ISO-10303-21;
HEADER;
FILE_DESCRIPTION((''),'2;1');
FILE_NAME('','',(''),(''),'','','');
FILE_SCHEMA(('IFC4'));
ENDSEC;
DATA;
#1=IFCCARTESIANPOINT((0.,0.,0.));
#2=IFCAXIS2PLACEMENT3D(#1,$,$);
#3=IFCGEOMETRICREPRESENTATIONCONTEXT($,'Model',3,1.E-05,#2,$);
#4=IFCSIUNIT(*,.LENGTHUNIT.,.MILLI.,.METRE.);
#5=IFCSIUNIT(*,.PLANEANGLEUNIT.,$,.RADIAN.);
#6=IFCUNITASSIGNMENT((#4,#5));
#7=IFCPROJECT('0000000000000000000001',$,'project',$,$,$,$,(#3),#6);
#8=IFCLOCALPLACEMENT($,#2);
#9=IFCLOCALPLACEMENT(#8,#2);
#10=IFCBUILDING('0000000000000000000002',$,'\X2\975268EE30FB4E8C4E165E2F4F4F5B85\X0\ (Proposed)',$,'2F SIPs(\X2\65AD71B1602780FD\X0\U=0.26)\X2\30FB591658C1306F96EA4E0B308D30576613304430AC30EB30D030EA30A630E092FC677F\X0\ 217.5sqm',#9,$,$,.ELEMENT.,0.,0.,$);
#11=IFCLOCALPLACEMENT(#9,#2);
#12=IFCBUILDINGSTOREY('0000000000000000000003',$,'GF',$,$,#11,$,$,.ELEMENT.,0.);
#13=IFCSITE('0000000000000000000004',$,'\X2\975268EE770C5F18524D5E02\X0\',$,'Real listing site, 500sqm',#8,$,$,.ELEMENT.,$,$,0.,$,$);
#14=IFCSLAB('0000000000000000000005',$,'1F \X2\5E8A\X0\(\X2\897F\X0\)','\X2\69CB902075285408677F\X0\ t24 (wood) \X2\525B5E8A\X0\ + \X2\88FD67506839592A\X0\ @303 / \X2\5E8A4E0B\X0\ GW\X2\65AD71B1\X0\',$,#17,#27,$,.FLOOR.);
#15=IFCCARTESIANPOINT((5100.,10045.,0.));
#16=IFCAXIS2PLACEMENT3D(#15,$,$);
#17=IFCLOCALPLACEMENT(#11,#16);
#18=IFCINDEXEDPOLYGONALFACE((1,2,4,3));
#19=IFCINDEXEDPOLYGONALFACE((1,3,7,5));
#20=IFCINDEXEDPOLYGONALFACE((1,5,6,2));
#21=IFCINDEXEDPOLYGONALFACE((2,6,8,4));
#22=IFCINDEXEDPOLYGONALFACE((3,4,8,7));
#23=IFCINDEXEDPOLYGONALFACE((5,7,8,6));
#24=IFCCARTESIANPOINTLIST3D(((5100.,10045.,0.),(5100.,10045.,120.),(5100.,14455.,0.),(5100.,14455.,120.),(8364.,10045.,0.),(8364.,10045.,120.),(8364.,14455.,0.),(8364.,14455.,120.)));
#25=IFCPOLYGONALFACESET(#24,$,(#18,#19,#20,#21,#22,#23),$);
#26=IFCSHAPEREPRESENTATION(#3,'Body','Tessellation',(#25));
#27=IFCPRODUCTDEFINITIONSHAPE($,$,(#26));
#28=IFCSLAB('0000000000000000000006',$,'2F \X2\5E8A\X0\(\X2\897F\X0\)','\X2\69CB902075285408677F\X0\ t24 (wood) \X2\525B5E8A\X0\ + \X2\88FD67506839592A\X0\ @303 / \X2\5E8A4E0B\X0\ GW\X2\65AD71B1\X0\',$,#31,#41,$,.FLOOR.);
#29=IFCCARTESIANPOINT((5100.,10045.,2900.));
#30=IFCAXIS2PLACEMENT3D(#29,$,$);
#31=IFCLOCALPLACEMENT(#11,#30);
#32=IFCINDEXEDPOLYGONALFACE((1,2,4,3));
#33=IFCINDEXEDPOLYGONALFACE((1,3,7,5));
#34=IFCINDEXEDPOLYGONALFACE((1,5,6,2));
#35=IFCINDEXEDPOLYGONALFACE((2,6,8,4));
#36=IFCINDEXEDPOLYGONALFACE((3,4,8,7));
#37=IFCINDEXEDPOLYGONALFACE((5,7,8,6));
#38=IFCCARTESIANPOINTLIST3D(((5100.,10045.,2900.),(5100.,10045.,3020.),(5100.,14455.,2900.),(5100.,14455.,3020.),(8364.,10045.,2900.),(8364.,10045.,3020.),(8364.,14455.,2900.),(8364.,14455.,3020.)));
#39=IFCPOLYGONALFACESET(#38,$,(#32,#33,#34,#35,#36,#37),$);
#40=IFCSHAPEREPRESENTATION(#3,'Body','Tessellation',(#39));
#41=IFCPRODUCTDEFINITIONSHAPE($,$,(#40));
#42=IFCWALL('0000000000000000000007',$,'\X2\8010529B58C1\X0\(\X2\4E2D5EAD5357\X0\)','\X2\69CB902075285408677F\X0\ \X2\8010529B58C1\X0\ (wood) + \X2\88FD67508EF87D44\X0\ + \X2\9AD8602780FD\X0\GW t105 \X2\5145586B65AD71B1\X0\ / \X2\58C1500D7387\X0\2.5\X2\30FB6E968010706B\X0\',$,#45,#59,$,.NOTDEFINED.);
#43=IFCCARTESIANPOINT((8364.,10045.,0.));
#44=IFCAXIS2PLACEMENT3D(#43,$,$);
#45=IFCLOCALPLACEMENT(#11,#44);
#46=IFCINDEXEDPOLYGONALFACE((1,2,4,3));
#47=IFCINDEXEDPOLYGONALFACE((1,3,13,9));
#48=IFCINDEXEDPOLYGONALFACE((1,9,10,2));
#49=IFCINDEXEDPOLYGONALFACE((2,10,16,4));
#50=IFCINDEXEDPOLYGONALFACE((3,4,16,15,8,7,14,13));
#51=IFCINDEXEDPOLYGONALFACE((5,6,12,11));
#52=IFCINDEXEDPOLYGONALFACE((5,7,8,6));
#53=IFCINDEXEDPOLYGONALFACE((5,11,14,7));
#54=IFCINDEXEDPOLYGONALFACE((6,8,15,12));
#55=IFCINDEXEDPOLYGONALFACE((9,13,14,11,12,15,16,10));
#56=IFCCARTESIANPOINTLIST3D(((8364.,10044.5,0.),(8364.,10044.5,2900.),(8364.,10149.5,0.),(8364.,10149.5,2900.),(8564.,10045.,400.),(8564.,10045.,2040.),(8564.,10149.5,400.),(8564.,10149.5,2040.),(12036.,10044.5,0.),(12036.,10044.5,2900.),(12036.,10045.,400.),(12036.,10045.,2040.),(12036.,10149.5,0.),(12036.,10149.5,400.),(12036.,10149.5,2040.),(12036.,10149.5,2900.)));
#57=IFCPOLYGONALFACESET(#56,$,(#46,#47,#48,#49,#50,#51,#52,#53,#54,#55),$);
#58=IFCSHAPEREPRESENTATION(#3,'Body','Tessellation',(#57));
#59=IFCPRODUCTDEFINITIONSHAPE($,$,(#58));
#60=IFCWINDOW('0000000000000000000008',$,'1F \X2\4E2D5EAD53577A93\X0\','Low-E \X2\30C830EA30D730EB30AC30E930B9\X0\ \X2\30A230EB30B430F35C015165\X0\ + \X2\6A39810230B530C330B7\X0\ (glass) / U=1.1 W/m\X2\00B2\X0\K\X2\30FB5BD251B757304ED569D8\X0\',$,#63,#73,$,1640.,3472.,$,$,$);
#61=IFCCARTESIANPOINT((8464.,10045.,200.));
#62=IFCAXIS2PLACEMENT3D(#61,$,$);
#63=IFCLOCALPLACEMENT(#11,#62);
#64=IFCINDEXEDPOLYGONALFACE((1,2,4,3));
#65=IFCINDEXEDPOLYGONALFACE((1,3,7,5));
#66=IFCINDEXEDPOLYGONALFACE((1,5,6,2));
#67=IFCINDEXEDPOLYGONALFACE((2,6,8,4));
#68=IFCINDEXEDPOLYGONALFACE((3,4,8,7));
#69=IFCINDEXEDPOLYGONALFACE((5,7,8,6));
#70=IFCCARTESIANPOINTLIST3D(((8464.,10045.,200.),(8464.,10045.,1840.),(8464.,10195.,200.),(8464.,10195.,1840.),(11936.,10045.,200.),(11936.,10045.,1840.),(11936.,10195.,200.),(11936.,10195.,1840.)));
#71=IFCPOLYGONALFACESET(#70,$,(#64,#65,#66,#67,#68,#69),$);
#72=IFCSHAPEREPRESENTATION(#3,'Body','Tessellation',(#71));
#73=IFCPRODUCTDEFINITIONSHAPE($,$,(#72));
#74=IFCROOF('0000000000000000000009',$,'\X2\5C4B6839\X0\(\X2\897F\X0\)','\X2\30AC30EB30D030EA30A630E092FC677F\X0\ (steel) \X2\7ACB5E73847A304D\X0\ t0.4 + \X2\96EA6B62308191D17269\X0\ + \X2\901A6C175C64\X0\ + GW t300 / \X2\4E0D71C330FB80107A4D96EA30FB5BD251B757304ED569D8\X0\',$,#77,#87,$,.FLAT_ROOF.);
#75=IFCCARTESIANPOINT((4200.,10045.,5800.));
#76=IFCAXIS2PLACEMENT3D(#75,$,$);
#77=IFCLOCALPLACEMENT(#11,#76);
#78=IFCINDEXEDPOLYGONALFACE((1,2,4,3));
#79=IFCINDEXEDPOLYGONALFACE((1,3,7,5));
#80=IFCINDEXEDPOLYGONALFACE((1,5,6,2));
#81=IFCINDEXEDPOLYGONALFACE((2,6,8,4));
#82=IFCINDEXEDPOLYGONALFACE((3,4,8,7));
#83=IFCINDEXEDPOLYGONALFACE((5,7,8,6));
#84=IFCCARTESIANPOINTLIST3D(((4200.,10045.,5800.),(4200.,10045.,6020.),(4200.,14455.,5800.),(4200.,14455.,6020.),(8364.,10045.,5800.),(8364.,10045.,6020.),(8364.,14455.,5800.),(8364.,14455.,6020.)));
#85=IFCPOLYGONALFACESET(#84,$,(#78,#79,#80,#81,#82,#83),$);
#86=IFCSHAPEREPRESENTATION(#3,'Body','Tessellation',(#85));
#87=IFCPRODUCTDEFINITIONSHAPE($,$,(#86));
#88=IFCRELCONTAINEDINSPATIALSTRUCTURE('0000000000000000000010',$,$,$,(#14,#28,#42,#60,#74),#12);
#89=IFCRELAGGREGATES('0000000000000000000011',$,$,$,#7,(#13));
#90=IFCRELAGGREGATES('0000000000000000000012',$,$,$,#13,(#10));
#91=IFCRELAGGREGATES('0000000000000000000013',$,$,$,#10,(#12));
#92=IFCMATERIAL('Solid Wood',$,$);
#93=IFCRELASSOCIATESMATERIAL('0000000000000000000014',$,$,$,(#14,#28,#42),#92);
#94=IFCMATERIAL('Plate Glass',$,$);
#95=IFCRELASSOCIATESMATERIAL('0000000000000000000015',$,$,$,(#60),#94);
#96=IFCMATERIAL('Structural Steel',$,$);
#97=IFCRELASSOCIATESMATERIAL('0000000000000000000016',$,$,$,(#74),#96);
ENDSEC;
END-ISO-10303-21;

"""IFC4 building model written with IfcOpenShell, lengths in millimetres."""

from ifc_helpers import new_model, si_unit, frame, frame_2d, origin, place, context, project, spatial, rectangle, extrude, material, element, fill, save


model = new_model("IFC4")

# Units and contexts
model_context = context("Model", 3, precision=1e-05, world=origin())
ifc_project = project(units=[si_unit("LENGTHUNIT", "METRE", prefix="MILLI"), si_unit("PLANEANGLEUNIT", "RADIAN")], contexts=[model_context])

# Site, building, storey
site_placement = place(None, origin())
site = spatial("IfcSite", under=ifc_project, at=site_placement, Name="青森県弘前市", ObjectType="Real listing site, 500sqm", CompositionType="ELEMENT", RefElevation=0.0)
building_placement = place(site_placement, origin())
building = spatial("IfcBuilding", under=site, at=building_placement, Name="青森・二世帯住宅 (Proposed)", ObjectType="2F SIPs(断熱性能U=0.26)・外壁は雪下ろし易いガルバリウム鋼板 217.5sqm", CompositionType="ELEMENT", ElevationOfRefHeight=0.0, ElevationOfTerrain=0.0)
storey_placement = place(building_placement, origin())
storey = spatial("IfcBuildingStorey", under=building, at=storey_placement, Name="GF", CompositionType="ELEMENT", Elevation=0.0)

# Shared definitions
ifc_material_1 = material(Name="Solid Wood")

# Slabs
slab_1_placement = place(storey_placement, frame((5100.0, 10045.0, 0.0)))
element("IfcSlab", 1, at=slab_1_placement, inside=storey, material=ifc_material_1, Name="1F 床(西)", Description="構造用合板 t24 (wood) 剛床 + 製材根太 @303 / 床下 GW断熱", PredefinedType="FLOOR", context=model_context, shape_type="SweptSolid", body=[
    extrude(rectangle(XDim=3264.0, YDim=4410.0, at=frame_2d((1632.0, 2205.0))), frame((5100.0, 10045.0, 0.0)), (0.0, 0.0, 1.0), 120.0),
])
slab_2_placement = place(storey_placement, frame((5100.0, 10045.0, 2900.0)))
element("IfcSlab", 2, at=slab_2_placement, inside=storey, material=ifc_material_1, Name="2F 床(西)", Description="構造用合板 t24 (wood) 剛床 + 製材根太 @303 / 床下 GW断熱", PredefinedType="FLOOR", context=model_context, shape_type="SweptSolid", body=[
    extrude(rectangle(XDim=3264.0, YDim=4410.0, at=frame_2d((1632.0, 2205.0))), frame((5100.0, 10045.0, 2900.0)), (0.0, 0.0, 1.0), 120.0),
])

# Wall, opening, window
wall_placement = place(storey_placement, frame((8364.0, 10045.0, 0.0)))
wall = element("IfcWall", 3, at=wall_placement, inside=storey, material=ifc_material_1, Name="耐力壁(中庭南)", Description="構造用合板 耐力壁 (wood) + 製材軸組 + 高性能GW t105 充填断熱 / 壁倍率2.5・準耐火", PredefinedType="NOTDEFINED", context=model_context, shape_type="SweptSolid", body=[
    extrude(rectangle(XDim=3672.0, YDim=105.0, at=frame_2d((1836.0, 52.0))), frame((8364.0, 10045.0, 0.0)), (0.0, 0.0, 1.0), 2900.0),
])
opening_placement = place(storey_placement, frame((8464.0, 10045.0, 200.0)))
opening = element("IfcOpeningElement", 4, at=opening_placement, cuts=wall, PredefinedType="NOTDEFINED", context=model_context, shape_type="SweptSolid", body=[
    extrude(rectangle(XDim=3472.0, YDim=150.0, at=frame_2d((1736.0, 75.0))), frame((8464.0, 10045.0, 200.0)), (0.0, 0.0, 1.0), 1640.0),
])
ifc_material_2 = material(Name="Plate Glass")
window_placement = place(storey_placement, frame((8464.0, 10045.0, 200.0)))
window = element("IfcWindow", 5, at=window_placement, inside=storey, material=ifc_material_2, Name="1F 中庭南窓", Description="Low-E トリプルガラス アルゴン封入 + 樹脂サッシ (glass) / U=1.1 W/m²K・寒冷地仕様", OverallHeight=1640.0, OverallWidth=3472.0, context=model_context, shape_type="SweptSolid", body=[
    extrude(rectangle(XDim=3472.0, YDim=150.0, at=frame_2d((1736.0, 75.0))), frame((8464.0, 10045.0, 200.0)), (0.0, 0.0, 1.0), 1640.0),
])
fill(opening, window)

# Roof
ifc_material_3 = material(Name="Structural Steel")
for number, where, name in (
    (6, (4200.0, 10045.0, 5800.0), "屋根(西)"),
):
    element("IfcRoof", number, at=place(storey_placement, frame(where)), inside=storey, material=ifc_material_3, Name=name, Description="ガルバリウム鋼板 (steel) 立平葺き t0.4 + 雪止め金物 + 通気層 + GW t300 / 不燃・耐積雪・寒冷地仕様", PredefinedType="FLAT_ROOF", context=model_context, shape_type="SweptSolid", body=[
        extrude(rectangle(XDim=4164.0, YDim=4410.0, at=frame_2d((2082.0, 2205.0))), frame((4200.0, 10045.0, 5800.0)), (0.0, 0.0, 1.0), 220.0),
    ])

save(model, "model.ifc")
